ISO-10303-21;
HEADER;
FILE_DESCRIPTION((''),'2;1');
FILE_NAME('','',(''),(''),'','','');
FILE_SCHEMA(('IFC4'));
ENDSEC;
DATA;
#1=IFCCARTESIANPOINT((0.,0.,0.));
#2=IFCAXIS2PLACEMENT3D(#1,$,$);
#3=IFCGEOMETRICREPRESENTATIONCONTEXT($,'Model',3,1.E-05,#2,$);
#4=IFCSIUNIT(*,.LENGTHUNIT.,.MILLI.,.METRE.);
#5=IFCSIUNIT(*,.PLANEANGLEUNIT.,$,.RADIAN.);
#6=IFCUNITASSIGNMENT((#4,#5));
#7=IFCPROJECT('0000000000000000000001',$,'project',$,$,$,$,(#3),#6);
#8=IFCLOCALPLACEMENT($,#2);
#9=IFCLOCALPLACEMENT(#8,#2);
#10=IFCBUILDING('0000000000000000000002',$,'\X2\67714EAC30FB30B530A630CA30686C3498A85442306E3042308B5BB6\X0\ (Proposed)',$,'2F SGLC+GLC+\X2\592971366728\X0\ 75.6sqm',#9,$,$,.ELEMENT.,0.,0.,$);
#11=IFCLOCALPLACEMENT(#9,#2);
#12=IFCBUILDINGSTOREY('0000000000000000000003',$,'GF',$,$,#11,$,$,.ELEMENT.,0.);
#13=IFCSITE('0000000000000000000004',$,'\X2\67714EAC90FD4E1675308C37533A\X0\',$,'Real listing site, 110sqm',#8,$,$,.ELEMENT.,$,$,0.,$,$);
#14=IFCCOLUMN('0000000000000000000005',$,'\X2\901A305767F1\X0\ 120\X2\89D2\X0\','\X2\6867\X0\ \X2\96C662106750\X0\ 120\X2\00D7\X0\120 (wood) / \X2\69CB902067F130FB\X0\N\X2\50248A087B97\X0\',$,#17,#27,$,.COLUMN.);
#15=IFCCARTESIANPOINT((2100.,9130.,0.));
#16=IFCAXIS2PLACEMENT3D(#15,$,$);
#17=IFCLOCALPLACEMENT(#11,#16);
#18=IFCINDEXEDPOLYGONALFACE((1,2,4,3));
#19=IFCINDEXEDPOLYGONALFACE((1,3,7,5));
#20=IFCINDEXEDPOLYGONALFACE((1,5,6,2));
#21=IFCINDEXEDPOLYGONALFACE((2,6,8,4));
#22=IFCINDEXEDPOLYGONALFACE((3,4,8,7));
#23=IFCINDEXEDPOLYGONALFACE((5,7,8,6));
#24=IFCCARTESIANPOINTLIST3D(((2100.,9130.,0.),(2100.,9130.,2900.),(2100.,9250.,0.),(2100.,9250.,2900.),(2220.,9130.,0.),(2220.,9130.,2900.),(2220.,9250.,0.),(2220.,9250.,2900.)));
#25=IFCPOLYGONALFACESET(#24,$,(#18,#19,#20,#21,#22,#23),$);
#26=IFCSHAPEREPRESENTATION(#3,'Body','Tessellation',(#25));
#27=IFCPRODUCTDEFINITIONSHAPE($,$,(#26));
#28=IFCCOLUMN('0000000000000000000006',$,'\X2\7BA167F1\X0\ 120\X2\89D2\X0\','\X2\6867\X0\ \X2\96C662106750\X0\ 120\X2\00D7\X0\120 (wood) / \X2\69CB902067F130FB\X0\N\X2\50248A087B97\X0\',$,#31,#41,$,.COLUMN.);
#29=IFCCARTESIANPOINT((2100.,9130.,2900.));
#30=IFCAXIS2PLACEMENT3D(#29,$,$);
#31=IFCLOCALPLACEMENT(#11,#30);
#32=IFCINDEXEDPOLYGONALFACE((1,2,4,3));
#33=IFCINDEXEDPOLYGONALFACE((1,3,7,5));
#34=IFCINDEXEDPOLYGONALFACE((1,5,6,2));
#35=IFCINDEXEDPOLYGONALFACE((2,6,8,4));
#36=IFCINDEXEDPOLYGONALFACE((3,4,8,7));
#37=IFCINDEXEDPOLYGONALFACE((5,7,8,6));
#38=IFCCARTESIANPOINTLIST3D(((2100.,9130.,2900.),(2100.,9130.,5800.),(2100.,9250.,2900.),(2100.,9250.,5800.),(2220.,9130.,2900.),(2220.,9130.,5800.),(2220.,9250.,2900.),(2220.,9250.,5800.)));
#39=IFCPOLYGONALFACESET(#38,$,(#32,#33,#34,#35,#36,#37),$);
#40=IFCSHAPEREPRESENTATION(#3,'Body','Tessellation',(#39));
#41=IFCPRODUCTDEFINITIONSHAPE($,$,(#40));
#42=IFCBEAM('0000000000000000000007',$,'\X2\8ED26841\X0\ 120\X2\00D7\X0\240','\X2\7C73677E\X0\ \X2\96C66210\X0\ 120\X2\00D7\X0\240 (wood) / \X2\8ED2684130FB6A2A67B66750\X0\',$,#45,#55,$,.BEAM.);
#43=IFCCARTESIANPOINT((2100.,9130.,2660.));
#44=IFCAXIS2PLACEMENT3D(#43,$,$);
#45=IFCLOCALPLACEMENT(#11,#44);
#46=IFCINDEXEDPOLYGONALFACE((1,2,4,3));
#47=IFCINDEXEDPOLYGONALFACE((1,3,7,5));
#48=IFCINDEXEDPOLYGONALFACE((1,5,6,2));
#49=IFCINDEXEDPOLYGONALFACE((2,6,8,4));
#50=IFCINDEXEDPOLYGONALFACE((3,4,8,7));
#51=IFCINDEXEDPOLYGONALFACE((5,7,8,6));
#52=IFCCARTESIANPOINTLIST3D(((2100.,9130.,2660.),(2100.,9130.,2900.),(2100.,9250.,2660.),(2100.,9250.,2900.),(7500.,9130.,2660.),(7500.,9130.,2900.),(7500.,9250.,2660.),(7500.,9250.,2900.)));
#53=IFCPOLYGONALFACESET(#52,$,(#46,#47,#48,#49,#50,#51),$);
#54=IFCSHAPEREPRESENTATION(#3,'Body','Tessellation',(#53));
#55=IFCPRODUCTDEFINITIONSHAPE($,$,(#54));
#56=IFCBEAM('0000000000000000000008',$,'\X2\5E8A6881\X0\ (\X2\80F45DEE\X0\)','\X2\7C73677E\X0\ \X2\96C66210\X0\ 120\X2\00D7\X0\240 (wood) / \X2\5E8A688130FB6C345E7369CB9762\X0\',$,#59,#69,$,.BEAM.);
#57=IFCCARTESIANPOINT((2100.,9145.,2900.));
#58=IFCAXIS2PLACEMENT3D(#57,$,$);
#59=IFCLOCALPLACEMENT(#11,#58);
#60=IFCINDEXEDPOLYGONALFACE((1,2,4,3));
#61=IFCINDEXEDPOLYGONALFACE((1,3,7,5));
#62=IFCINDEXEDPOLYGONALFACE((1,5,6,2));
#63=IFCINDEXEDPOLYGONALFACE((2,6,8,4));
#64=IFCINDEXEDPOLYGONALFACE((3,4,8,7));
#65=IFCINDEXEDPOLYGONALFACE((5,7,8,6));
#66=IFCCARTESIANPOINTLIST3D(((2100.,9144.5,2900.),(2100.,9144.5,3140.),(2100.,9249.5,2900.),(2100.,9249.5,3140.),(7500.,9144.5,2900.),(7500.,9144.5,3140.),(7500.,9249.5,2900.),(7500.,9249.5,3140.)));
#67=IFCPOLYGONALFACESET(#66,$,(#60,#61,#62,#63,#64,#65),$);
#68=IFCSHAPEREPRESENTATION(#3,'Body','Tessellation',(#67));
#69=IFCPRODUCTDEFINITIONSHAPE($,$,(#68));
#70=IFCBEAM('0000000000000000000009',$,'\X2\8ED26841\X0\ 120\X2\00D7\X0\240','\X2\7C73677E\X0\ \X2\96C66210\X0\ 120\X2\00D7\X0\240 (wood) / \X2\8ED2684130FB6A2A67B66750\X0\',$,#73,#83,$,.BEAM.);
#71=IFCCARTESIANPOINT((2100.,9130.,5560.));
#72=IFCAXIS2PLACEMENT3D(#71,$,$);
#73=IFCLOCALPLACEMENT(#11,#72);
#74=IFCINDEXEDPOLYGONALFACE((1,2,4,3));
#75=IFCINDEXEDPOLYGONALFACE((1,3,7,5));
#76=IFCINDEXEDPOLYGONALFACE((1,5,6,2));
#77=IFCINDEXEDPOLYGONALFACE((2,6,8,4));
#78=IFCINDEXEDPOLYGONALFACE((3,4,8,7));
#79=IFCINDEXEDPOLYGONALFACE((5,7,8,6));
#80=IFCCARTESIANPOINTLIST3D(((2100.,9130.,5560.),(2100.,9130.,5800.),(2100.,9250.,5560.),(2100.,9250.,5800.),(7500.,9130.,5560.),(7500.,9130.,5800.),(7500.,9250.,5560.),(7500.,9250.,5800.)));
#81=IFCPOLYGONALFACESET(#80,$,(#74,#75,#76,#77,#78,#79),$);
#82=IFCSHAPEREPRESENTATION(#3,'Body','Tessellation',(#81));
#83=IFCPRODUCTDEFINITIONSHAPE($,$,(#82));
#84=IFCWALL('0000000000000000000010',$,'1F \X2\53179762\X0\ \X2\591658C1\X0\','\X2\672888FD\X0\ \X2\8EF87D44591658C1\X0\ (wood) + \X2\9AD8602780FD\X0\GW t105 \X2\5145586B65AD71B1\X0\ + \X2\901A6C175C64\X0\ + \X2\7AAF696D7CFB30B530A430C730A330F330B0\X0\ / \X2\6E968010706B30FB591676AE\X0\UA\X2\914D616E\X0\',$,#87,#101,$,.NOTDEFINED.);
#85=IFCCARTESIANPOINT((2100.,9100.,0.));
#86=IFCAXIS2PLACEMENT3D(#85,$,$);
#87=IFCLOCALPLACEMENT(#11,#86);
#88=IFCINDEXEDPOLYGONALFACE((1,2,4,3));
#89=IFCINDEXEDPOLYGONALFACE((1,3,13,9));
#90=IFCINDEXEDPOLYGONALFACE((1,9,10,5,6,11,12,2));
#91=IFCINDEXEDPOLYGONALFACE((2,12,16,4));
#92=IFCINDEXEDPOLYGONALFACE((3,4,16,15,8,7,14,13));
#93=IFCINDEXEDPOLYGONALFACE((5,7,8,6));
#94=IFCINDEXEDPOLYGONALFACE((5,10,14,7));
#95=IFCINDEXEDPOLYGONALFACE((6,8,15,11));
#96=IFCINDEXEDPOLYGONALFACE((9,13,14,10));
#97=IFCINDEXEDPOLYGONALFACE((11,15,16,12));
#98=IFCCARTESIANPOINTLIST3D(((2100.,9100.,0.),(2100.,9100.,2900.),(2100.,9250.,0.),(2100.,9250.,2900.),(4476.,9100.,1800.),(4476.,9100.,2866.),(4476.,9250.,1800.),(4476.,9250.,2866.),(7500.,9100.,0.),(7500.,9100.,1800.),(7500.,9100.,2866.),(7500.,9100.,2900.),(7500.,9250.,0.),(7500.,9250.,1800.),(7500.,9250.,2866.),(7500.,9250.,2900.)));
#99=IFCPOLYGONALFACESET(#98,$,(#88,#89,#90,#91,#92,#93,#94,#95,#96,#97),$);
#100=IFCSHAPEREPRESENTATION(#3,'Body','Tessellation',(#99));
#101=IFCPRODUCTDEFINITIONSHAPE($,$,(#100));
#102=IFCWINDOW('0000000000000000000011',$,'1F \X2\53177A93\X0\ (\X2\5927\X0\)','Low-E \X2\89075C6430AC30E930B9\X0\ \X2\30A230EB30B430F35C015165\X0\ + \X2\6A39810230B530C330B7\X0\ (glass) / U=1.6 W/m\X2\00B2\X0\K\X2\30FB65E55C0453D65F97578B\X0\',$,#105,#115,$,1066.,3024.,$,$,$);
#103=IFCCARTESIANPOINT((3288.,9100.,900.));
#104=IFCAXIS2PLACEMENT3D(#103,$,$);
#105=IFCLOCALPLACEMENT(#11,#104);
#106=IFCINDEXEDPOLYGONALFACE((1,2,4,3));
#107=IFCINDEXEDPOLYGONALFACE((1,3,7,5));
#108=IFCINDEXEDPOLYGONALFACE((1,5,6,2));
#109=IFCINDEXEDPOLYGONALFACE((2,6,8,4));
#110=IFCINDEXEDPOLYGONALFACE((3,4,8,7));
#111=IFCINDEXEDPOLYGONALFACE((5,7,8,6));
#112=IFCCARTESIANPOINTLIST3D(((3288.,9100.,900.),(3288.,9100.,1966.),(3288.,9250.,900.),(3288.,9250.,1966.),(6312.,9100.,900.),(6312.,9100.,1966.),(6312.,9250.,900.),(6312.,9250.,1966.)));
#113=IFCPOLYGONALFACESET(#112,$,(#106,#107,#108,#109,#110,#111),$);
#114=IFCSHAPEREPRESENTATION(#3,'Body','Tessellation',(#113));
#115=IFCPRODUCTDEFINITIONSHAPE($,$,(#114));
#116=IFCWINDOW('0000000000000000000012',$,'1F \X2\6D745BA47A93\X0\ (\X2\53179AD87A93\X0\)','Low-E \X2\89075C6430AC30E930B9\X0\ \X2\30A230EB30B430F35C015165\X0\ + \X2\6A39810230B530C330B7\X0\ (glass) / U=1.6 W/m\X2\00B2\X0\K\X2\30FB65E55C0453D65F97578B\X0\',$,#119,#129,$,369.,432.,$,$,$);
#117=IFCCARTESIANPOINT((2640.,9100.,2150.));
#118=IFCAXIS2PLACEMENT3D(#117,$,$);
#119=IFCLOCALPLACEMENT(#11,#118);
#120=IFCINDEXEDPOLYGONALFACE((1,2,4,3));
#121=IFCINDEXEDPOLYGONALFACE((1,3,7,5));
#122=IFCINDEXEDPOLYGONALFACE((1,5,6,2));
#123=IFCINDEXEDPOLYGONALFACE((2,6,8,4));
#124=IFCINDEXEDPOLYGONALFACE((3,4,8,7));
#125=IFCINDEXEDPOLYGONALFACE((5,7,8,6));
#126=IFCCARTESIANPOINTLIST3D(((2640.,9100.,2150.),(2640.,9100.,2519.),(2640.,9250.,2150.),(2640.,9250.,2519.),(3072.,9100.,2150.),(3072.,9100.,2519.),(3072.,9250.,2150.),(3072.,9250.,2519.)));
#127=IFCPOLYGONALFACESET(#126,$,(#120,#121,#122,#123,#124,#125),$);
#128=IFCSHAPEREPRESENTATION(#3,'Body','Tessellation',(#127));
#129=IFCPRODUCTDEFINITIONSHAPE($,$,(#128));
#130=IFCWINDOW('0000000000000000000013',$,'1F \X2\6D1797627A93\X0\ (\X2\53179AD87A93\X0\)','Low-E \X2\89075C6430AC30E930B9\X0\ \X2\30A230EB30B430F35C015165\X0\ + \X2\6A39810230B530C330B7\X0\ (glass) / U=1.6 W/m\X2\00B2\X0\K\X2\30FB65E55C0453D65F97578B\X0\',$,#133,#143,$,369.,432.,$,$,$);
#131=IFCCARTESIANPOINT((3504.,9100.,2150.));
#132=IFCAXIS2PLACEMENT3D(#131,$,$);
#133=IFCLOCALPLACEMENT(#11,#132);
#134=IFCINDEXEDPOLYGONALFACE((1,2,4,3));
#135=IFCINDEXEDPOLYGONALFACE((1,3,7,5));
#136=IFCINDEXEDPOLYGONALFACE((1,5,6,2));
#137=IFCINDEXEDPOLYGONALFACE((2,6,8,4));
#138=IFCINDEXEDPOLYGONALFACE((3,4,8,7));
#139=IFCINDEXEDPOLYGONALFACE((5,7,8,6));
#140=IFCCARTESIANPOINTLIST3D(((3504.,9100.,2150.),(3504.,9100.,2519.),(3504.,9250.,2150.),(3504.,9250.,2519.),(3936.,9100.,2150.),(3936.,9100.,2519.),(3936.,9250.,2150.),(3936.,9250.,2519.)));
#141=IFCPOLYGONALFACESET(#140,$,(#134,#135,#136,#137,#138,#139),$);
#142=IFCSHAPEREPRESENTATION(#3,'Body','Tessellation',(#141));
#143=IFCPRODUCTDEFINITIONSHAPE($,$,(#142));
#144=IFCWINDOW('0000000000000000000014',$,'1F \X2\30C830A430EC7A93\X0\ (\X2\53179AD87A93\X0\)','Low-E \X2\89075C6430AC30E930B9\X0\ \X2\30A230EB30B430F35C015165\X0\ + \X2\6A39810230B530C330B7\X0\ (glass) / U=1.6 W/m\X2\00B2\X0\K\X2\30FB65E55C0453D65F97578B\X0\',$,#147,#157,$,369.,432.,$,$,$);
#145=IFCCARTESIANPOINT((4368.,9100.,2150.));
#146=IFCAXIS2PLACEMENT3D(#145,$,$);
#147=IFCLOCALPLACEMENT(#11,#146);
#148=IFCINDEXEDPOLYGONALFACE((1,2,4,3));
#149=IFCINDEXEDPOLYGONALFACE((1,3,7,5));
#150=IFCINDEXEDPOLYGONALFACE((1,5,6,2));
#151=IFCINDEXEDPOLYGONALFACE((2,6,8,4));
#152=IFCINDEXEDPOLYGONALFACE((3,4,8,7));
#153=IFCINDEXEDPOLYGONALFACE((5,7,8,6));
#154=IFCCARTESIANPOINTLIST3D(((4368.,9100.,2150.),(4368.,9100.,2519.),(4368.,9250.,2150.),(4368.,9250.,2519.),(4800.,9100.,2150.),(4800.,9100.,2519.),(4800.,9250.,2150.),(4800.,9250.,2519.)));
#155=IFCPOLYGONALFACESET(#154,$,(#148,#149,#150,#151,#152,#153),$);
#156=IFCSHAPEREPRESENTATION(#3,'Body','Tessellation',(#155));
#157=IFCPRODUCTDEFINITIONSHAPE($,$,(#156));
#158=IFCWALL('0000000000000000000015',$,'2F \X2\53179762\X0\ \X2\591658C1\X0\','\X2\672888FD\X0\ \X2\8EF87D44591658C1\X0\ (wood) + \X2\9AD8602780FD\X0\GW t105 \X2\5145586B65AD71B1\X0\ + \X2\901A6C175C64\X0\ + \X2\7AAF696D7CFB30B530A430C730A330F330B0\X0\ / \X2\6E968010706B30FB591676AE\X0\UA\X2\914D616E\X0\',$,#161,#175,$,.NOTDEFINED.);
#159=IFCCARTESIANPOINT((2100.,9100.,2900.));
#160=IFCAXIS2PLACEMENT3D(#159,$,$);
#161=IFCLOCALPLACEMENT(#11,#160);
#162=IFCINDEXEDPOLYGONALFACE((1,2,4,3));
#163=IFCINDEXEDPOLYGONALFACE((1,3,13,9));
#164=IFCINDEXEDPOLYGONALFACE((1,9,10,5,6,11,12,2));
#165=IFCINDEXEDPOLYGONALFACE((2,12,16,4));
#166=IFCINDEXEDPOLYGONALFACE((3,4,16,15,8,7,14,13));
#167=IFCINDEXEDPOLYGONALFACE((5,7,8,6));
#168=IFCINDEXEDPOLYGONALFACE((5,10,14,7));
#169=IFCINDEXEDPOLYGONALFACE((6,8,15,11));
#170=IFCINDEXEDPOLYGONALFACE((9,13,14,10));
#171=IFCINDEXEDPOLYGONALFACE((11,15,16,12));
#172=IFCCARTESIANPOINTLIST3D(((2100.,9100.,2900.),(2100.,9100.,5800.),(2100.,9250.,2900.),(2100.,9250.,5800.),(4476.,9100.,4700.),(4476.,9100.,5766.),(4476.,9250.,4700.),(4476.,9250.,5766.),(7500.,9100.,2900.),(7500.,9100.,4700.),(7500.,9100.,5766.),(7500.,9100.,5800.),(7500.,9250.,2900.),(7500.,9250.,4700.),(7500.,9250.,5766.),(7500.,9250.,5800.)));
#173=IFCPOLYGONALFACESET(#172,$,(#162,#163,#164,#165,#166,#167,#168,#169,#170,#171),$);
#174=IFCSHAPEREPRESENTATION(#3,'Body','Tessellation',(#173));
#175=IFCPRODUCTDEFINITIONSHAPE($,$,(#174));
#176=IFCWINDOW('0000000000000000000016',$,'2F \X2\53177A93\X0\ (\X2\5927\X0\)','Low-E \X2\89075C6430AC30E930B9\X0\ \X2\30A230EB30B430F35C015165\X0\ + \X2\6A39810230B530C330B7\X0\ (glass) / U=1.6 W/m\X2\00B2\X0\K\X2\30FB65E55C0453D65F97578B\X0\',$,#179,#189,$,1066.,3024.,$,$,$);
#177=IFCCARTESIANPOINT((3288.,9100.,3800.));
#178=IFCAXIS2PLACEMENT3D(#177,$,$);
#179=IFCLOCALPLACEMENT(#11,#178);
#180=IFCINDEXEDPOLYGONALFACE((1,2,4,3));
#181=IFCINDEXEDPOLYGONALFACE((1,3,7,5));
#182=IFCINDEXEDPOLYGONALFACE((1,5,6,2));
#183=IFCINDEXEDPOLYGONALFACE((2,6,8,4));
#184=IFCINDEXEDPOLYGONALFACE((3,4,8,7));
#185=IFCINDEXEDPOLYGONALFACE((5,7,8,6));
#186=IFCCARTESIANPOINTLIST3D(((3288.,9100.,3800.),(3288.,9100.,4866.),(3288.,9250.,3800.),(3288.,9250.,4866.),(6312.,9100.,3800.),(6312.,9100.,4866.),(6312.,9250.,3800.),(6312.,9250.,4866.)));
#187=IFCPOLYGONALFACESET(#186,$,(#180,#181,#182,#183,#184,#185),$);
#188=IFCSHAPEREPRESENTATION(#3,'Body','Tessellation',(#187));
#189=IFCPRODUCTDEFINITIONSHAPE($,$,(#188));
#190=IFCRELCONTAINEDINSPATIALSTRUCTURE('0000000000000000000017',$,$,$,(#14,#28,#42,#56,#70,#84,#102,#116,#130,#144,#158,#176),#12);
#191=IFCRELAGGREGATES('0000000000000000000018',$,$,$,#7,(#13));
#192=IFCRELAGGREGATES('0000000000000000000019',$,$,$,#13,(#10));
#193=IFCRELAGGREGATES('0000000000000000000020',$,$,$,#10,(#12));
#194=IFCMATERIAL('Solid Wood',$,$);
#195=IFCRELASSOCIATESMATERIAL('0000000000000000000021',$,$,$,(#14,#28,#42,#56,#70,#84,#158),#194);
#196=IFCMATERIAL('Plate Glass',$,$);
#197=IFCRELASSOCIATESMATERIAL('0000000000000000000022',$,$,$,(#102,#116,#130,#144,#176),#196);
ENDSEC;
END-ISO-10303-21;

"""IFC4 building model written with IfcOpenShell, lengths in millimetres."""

from ifc_helpers import new_model, si_unit, frame, frame_2d, origin, place, context, project, spatial, rectangle, extrude, material, element, fill, save


model = new_model("IFC4")

# Units and contexts
model_context = context("Model", 3, precision=1e-05, world=origin())
ifc_project = project(units=[si_unit("LENGTHUNIT", "METRE", prefix="MILLI"), si_unit("PLANEANGLEUNIT", "RADIAN")], contexts=[model_context])

# Site, building, storey
site_placement = place(None, origin())
site = spatial("IfcSite", under=ifc_project, at=site_placement, Name="東京都世田谷区", ObjectType="Real listing site, 110sqm", CompositionType="ELEMENT", RefElevation=0.0)
building_placement = place(site_placement, origin())
building = spatial("IfcBuilding", under=site, at=building_placement, Name="東京・サウナと水風呂のある家 (Proposed)", ObjectType="2F SGLC+GLC+天然木 75.6sqm", CompositionType="ELEMENT", ElevationOfRefHeight=0.0, ElevationOfTerrain=0.0)
storey_placement = place(building_placement, origin())
storey = spatial("IfcBuildingStorey", under=building, at=storey_placement, Name="GF", CompositionType="ELEMENT", Elevation=0.0)

# Columns
ifc_material_1 = material(Name="Solid Wood")
column_1_placement = place(storey_placement, frame((2100.0, 9130.0, 0.0)))
element("IfcColumn", 1, at=column_1_placement, inside=storey, material=ifc_material_1, Name="通し柱 120角", Description="桧 集成材 120×120 (wood) / 構造柱・N値計算", PredefinedType="COLUMN", context=model_context, shape_type="SweptSolid", body=[
    extrude(rectangle(XDim=120.0, YDim=120.0, at=frame_2d((60.0, 60.0))), frame((2100.0, 9130.0, 0.0)), (0.0, 0.0, 1.0), 2900.0),
])
column_2_placement = place(storey_placement, frame((2100.0, 9130.0, 2900.0)))
element("IfcColumn", 2, at=column_2_placement, inside=storey, material=ifc_material_1, Name="管柱 120角", Description="桧 集成材 120×120 (wood) / 構造柱・N値計算", PredefinedType="COLUMN", context=model_context, shape_type="SweptSolid", body=[
    extrude(rectangle(XDim=120.0, YDim=120.0, at=frame_2d((60.0, 60.0))), frame((2100.0, 9130.0, 2900.0)), (0.0, 0.0, 1.0), 2900.0),
])

# Beams
beam_1_placement = place(storey_placement, frame((2100.0, 9130.0, 2660.0)))
element("IfcBeam", 3, at=beam_1_placement, inside=storey, material=ifc_material_1, Name="軒桁 120×240", Description="米松 集成 120×240 (wood) / 軒桁・横架材", PredefinedType="BEAM", context=model_context, shape_type="SweptSolid", body=[
    extrude(rectangle(XDim=5400.0, YDim=120.0, at=frame_2d((2700.0, 60.0))), frame((2100.0, 9130.0, 2660.0)), (0.0, 0.0, 1.0), 240.0),
])
beam_2_placement = place(storey_placement, frame((2100.0, 9145.0, 2900.0)))
element("IfcBeam", 4, at=beam_2_placement, inside=storey, material=ifc_material_1, Name="床梁 (胴差)", Description="米松 集成 120×240 (wood) / 床梁・水平構面", PredefinedType="BEAM", context=model_context, shape_type="SweptSolid", body=[
    extrude(rectangle(XDim=5400.0, YDim=105.0, at=frame_2d((2700.0, 52.0))), frame((2100.0, 9145.0, 2900.0)), (0.0, 0.0, 1.0), 240.0),
])
beam_3_placement = place(storey_placement, frame((2100.0, 9130.0, 5560.0)))
element("IfcBeam", 5, at=beam_3_placement, inside=storey, material=ifc_material_1, Name="軒桁 120×240", Description="米松 集成 120×240 (wood) / 軒桁・横架材", PredefinedType="BEAM", context=model_context, shape_type="SweptSolid", body=[
    extrude(rectangle(XDim=5400.0, YDim=120.0, at=frame_2d((2700.0, 60.0))), frame((2100.0, 9130.0, 5560.0)), (0.0, 0.0, 1.0), 240.0),
])

# Wall, openings, windows
wall_1_placement = place(storey_placement, frame((2100.0, 9100.0, 0.0)))
wall_1 = element("IfcWall", 6, at=wall_1_placement, inside=storey, material=ifc_material_1, Name="1F 北面 外壁", Description="木製 軸組外壁 (wood) + 高性能GW t105 充填断熱 + 通気層 + 窯業系サイディング / 準耐火・外皮UA配慮", PredefinedType="NOTDEFINED", context=model_context, shape_type="SweptSolid", body=[
    extrude(rectangle(XDim=5400.0, YDim=150.0, at=frame_2d((2700.0, 75.0))), frame((2100.0, 9100.0, 0.0)), (0.0, 0.0, 1.0), 2900.0),
])
opening_1_placement = place(storey_placement, frame((3288.0, 9100.0, 900.0)))
opening_1 = element("IfcOpeningElement", 7, at=opening_1_placement, cuts=wall_1, PredefinedType="NOTDEFINED", context=model_context, shape_type="SweptSolid", body=[
    extrude(rectangle(XDim=3024.0, YDim=150.0, at=frame_2d((1512.0, 75.0))), frame((3288.0, 9100.0, 900.0)), (0.0, 0.0, 1.0), 1066.0),
])
opening_2_placement = place(storey_placement, frame((2640.0, 9100.0, 2150.0)))
opening_2 = element("IfcOpeningElement", 8, at=opening_2_placement, cuts=wall_1, PredefinedType="NOTDEFINED", context=model_context, shape_type="SweptSolid", body=[
    extrude(rectangle(XDim=432.0, YDim=150.0, at=frame_2d((216.0, 75.0))), frame((2640.0, 9100.0, 2150.0)), (0.0, 0.0, 1.0), 369.0),
])
opening_3_placement = place(storey_placement, frame((3504.0, 9100.0, 2150.0)))
opening_3 = element("IfcOpeningElement", 9, at=opening_3_placement, cuts=wall_1, PredefinedType="NOTDEFINED", context=model_context, shape_type="SweptSolid", body=[
    extrude(rectangle(XDim=432.0, YDim=150.0, at=frame_2d((216.0, 75.0))), frame((3504.0, 9100.0, 2150.0)), (0.0, 0.0, 1.0), 369.0),
])
opening_4_placement = place(storey_placement, frame((4368.0, 9100.0, 2150.0)))
opening_4 = element("IfcOpeningElement", 10, at=opening_4_placement, cuts=wall_1, PredefinedType="NOTDEFINED", context=model_context, shape_type="SweptSolid", body=[
    extrude(rectangle(XDim=432.0, YDim=150.0, at=frame_2d((216.0, 75.0))), frame((4368.0, 9100.0, 2150.0)), (0.0, 0.0, 1.0), 369.0),
])
ifc_material_2 = material(Name="Plate Glass")
window_1_placement = place(storey_placement, frame((3288.0, 9100.0, 900.0)))
window_1 = element("IfcWindow", 11, at=window_1_placement, inside=storey, material=ifc_material_2, Name="1F 北窓 (大)", Description="Low-E 複層ガラス アルゴン封入 + 樹脂サッシ (glass) / U=1.6 W/m²K・日射取得型", OverallHeight=1066.0, OverallWidth=3024.0, context=model_context, shape_type="SweptSolid", body=[
    extrude(rectangle(XDim=3024.0, YDim=150.0, at=frame_2d((1512.0, 75.0))), frame((3288.0, 9100.0, 900.0)), (0.0, 0.0, 1.0), 1066.0),
])
fill(opening_1, window_1)
window_2_placement = place(storey_placement, frame((2640.0, 9100.0, 2150.0)))
window_2 = element("IfcWindow", 12, at=window_2_placement, inside=storey, material=ifc_material_2, Name="1F 浴室窓 (北高窓)", Description="Low-E 複層ガラス アルゴン封入 + 樹脂サッシ (glass) / U=1.6 W/m²K・日射取得型", OverallHeight=369.0, OverallWidth=432.0, context=model_context, shape_type="SweptSolid", body=[
    extrude(rectangle(XDim=432.0, YDim=150.0, at=frame_2d((216.0, 75.0))), frame((2640.0, 9100.0, 2150.0)), (0.0, 0.0, 1.0), 369.0),
])
fill(opening_2, window_2)
window_3_placement = place(storey_placement, frame((3504.0, 9100.0, 2150.0)))
window_3 = element("IfcWindow", 13, at=window_3_placement, inside=storey, material=ifc_material_2, Name="1F 洗面窓 (北高窓)", Description="Low-E 複層ガラス アルゴン封入 + 樹脂サッシ (glass) / U=1.6 W/m²K・日射取得型", OverallHeight=369.0, OverallWidth=432.0, context=model_context, shape_type="SweptSolid", body=[
    extrude(rectangle(XDim=432.0, YDim=150.0, at=frame_2d((216.0, 75.0))), frame((3504.0, 9100.0, 2150.0)), (0.0, 0.0, 1.0), 369.0),
])
fill(opening_3, window_3)
window_4_placement = place(storey_placement, frame((4368.0, 9100.0, 2150.0)))
window_4 = element("IfcWindow", 14, at=window_4_placement, inside=storey, material=ifc_material_2, Name="1F トイレ窓 (北高窓)", Description="Low-E 複層ガラス アルゴン封入 + 樹脂サッシ (glass) / U=1.6 W/m²K・日射取得型", OverallHeight=369.0, OverallWidth=432.0, context=model_context, shape_type="SweptSolid", body=[
    extrude(rectangle(XDim=432.0, YDim=150.0, at=frame_2d((216.0, 75.0))), frame((4368.0, 9100.0, 2150.0)), (0.0, 0.0, 1.0), 369.0),
])
fill(opening_4, window_4)

# Wall, opening, window
wall_2_placement = place(storey_placement, frame((2100.0, 9100.0, 2900.0)))
wall_2 = element("IfcWall", 15, at=wall_2_placement, inside=storey, material=ifc_material_1, Name="2F 北面 外壁", Description="木製 軸組外壁 (wood) + 高性能GW t105 充填断熱 + 通気層 + 窯業系サイディング / 準耐火・外皮UA配慮", PredefinedType="NOTDEFINED", context=model_context, shape_type="SweptSolid", body=[
    extrude(rectangle(XDim=5400.0, YDim=150.0, at=frame_2d((2700.0, 75.0))), frame((2100.0, 9100.0, 2900.0)), (0.0, 0.0, 1.0), 2900.0),
])
opening_5_placement = place(storey_placement, frame((3288.0, 9100.0, 3800.0)))
opening_5 = element("IfcOpeningElement", 16, at=opening_5_placement, cuts=wall_2, PredefinedType="NOTDEFINED", context=model_context, shape_type="SweptSolid", body=[
    extrude(rectangle(XDim=3024.0, YDim=150.0, at=frame_2d((1512.0, 75.0))), frame((3288.0, 9100.0, 3800.0)), (0.0, 0.0, 1.0), 1066.0),
])
window_5_placement = place(storey_placement, frame((3288.0, 9100.0, 3800.0)))
window_5 = element("IfcWindow", 17, at=window_5_placement, inside=storey, material=ifc_material_2, Name="2F 北窓 (大)", Description="Low-E 複層ガラス アルゴン封入 + 樹脂サッシ (glass) / U=1.6 W/m²K・日射取得型", OverallHeight=1066.0, OverallWidth=3024.0, context=model_context, shape_type="SweptSolid", body=[
    extrude(rectangle(XDim=3024.0, YDim=150.0, at=frame_2d((1512.0, 75.0))), frame((3288.0, 9100.0, 3800.0)), (0.0, 0.0, 1.0), 1066.0),
])
fill(opening_5, window_5)

save(model, "model.ifc")
